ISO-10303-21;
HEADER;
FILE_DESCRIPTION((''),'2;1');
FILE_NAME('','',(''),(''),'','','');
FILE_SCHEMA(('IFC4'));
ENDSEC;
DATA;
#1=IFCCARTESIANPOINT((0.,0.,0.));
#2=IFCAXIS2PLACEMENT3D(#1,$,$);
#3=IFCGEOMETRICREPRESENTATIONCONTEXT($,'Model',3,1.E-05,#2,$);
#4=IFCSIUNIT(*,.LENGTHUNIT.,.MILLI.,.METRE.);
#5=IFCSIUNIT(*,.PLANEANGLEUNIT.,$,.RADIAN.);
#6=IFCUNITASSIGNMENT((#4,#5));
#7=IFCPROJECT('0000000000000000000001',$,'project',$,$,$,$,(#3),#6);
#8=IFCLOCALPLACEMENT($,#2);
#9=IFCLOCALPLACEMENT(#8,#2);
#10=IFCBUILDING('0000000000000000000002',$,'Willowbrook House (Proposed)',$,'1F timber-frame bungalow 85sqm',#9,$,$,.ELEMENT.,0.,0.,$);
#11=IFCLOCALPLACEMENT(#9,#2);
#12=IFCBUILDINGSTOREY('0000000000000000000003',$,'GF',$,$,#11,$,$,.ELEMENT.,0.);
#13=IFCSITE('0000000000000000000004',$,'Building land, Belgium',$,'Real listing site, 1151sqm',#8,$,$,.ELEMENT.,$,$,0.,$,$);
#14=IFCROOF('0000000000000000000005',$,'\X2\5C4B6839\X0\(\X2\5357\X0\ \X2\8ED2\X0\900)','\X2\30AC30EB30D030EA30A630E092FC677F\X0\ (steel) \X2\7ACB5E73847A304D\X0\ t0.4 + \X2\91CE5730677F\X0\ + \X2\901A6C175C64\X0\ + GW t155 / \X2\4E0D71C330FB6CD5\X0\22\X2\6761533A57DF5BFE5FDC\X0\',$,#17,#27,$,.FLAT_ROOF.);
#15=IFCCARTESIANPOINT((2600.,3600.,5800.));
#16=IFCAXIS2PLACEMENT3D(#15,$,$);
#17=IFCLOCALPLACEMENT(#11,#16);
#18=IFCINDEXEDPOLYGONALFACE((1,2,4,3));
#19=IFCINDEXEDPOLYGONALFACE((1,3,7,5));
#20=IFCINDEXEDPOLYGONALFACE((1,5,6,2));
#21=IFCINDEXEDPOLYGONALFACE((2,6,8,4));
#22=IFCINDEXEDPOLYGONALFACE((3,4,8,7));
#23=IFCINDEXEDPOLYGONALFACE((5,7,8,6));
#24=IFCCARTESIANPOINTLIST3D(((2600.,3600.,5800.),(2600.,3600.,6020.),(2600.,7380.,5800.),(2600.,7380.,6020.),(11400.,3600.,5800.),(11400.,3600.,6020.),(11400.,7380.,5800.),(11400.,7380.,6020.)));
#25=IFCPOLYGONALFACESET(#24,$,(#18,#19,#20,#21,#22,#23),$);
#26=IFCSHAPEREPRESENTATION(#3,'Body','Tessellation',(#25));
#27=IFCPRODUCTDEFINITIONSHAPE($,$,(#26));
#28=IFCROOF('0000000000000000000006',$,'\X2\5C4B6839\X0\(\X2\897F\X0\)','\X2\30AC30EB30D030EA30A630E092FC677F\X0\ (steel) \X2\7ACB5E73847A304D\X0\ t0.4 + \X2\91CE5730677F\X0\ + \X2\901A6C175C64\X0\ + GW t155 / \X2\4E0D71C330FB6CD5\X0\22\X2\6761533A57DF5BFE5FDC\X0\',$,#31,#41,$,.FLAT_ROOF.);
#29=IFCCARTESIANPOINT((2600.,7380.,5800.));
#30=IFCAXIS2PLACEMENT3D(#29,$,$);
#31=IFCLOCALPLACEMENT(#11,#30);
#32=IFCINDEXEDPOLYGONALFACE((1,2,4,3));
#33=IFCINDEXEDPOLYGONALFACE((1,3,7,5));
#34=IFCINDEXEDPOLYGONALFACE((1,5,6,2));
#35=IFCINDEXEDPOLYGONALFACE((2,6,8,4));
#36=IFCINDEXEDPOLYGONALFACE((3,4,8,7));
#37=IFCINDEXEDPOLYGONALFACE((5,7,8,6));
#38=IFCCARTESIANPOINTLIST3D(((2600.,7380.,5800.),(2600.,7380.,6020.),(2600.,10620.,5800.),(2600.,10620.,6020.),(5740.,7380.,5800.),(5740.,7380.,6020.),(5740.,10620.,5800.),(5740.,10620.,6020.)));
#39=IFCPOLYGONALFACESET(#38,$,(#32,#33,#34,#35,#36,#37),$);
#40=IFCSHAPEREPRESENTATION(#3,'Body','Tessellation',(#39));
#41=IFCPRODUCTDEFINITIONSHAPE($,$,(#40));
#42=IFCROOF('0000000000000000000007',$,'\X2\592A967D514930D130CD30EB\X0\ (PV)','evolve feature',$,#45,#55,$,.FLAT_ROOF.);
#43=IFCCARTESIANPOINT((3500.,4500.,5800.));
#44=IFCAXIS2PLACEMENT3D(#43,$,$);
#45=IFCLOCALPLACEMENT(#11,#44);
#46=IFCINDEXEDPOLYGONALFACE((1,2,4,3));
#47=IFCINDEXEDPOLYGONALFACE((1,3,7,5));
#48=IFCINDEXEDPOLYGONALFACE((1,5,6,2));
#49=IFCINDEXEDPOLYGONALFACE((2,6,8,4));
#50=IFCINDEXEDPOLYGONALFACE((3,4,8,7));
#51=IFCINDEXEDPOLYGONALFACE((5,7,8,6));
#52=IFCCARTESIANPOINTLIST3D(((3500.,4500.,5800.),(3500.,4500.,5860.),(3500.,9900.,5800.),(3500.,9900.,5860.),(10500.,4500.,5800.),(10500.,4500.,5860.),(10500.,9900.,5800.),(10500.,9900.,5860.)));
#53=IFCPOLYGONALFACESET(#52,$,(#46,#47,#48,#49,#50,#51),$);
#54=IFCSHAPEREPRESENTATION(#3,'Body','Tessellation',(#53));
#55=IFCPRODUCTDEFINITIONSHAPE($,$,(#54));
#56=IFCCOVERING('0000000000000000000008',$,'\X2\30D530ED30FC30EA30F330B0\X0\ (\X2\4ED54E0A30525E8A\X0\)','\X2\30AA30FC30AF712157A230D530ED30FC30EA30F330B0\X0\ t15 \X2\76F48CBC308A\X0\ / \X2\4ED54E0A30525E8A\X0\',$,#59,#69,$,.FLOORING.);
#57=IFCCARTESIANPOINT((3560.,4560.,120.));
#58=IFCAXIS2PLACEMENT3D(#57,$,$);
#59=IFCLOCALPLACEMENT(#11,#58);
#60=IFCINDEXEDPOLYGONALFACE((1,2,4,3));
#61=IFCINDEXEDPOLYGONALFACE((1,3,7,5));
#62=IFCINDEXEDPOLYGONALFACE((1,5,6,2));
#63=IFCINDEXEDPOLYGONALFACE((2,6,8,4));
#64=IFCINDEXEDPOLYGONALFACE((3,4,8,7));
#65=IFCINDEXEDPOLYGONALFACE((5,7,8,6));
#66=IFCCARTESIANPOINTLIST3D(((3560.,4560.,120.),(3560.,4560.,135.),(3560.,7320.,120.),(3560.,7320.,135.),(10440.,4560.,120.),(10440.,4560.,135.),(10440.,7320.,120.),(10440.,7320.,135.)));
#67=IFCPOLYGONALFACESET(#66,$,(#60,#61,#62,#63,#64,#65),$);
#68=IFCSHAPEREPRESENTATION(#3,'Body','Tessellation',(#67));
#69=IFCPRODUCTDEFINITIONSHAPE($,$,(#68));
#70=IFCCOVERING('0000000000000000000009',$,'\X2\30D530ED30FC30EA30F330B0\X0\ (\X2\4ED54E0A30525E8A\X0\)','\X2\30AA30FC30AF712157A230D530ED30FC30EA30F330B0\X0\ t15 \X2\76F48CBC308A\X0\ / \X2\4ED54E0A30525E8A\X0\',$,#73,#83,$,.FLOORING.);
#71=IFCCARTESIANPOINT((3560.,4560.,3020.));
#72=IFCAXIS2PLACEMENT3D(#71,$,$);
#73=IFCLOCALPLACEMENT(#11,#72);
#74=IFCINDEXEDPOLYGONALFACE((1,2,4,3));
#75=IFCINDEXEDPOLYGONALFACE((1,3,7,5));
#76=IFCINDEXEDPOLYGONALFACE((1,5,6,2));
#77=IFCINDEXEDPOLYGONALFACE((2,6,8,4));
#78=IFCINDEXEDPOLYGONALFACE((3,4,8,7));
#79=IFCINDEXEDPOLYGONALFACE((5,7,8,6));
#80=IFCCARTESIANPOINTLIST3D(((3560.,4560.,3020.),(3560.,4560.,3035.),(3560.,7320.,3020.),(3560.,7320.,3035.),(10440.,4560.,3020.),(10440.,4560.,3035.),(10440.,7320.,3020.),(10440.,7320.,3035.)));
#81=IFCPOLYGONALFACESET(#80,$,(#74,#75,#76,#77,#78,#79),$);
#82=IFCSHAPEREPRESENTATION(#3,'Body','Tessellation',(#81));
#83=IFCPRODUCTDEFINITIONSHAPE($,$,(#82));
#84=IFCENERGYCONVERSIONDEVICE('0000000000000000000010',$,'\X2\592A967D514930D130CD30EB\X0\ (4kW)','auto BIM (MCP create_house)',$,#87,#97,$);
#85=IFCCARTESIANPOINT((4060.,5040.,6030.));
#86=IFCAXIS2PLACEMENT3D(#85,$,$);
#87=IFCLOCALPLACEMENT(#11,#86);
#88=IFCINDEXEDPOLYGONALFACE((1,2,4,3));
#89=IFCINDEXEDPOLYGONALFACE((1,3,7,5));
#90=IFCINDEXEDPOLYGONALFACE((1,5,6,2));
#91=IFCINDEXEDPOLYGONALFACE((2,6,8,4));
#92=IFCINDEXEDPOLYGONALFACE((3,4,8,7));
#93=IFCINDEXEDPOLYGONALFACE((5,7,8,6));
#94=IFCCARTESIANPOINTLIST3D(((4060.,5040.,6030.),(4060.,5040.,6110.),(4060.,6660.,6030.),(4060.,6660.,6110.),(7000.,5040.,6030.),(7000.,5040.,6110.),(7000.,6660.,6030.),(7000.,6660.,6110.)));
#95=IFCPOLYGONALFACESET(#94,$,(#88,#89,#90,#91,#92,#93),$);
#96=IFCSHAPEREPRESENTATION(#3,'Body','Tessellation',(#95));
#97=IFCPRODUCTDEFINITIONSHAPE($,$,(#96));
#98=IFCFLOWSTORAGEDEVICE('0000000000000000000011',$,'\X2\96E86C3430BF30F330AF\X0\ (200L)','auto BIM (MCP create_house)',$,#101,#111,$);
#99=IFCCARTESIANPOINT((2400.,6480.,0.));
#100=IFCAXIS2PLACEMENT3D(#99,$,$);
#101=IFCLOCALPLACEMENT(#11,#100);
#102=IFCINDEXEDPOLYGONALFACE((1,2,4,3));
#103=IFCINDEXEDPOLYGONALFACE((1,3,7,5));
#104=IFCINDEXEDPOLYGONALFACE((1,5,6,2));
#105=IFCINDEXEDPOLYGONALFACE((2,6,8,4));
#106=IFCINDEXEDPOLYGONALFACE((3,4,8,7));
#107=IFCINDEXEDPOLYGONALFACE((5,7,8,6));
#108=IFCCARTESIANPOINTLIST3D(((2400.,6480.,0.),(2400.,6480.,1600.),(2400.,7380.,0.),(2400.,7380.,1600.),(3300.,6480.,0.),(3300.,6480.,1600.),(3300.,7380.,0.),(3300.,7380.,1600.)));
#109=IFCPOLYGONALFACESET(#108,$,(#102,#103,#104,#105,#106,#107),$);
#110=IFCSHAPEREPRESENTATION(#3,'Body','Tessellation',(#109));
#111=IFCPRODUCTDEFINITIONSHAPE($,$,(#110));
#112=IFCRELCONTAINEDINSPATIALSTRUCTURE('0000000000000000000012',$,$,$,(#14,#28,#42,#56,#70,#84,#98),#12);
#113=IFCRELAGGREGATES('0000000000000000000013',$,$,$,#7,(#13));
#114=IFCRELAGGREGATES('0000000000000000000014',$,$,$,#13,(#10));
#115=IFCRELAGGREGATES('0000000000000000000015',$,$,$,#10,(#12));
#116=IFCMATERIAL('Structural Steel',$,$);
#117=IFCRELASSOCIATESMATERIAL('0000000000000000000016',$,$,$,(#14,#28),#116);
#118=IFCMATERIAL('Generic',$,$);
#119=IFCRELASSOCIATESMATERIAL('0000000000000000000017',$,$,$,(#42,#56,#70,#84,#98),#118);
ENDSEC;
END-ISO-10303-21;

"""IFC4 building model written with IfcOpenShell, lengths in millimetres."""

from ifc_helpers import new_model, si_unit, frame, frame_2d, origin, place, context, project, spatial, rectangle, extrude, material, element, save


model = new_model("IFC4")

# Units and contexts
model_context = context("Model", 3, precision=1e-05, world=origin())
ifc_project = project(units=[si_unit("LENGTHUNIT", "METRE", prefix="MILLI"), si_unit("PLANEANGLEUNIT", "RADIAN")], contexts=[model_context])

# Site, building, storey
site_placement = place(None, origin())
site = spatial("IfcSite", under=ifc_project, at=site_placement, Name="Building land, Belgium", ObjectType="Real listing site, 1151sqm", CompositionType="ELEMENT", RefElevation=0.0)
building_placement = place(site_placement, origin())
building = spatial("IfcBuilding", under=site, at=building_placement, Name="Willowbrook House (Proposed)", ObjectType="1F timber-frame bungalow 85sqm", CompositionType="ELEMENT", ElevationOfRefHeight=0.0, ElevationOfTerrain=0.0)
storey_placement = place(building_placement, origin())
storey = spatial("IfcBuildingStorey", under=building, at=storey_placement, Name="GF", CompositionType="ELEMENT", Elevation=0.0)

# Shared definitions
ifc_material_1 = material(Name="Generic")

# Roofs
ifc_material_2 = material(Name="Structural Steel")
roof_1_placement = place(storey_placement, frame((2600.0, 3600.0, 5800.0)))
element("IfcRoof", 1, at=roof_1_placement, inside=storey, material=ifc_material_2, Name="屋根(南 軒900)", Description="ガルバリウム鋼板 (steel) 立平葺き t0.4 + 野地板 + 通気層 + GW t155 / 不燃・法22条区域対応", PredefinedType="FLAT_ROOF", context=model_context, shape_type="SweptSolid", body=[
    extrude(rectangle(XDim=8800.0, YDim=3780.0, at=frame_2d((4400.0, 1890.0))), frame((2600.0, 3600.0, 5800.0)), (0.0, 0.0, 1.0), 220.0),
])
roof_2_placement = place(storey_placement, frame((2600.0, 7380.0, 5800.0)))
element("IfcRoof", 2, at=roof_2_placement, inside=storey, material=ifc_material_2, Name="屋根(西)", Description="ガルバリウム鋼板 (steel) 立平葺き t0.4 + 野地板 + 通気層 + GW t155 / 不燃・法22条区域対応", PredefinedType="FLAT_ROOF", context=model_context, shape_type="SweptSolid", body=[
    extrude(rectangle(XDim=3140.0, YDim=3240.0, at=frame_2d((1570.0, 1620.0))), frame((2600.0, 7380.0, 5800.0)), (0.0, 0.0, 1.0), 220.0),
])
roof_3_placement = place(storey_placement, frame((3500.0, 4500.0, 5800.0)))
element("IfcRoof", 3, at=roof_3_placement, inside=storey, material=ifc_material_1, Name="太陽光パネル (PV)", Description="evolve feature", PredefinedType="FLAT_ROOF", context=model_context, shape_type="SweptSolid", body=[
    extrude(rectangle(XDim=7000.0, YDim=5400.0, at=frame_2d((3500.0, 2700.0))), frame((3500.0, 4500.0, 5800.0)), (0.0, 0.0, 1.0), 60.0),
])

# Coverings
covering_1_placement = place(storey_placement, frame((3560.0, 4560.0, 120.0)))
element("IfcCovering", 4, at=covering_1_placement, inside=storey, material=ifc_material_1, Name="フローリング (仕上げ床)", Description="オーク無垢フローリング t15 直貼り / 仕上げ床", PredefinedType="FLOORING", context=model_context, shape_type="SweptSolid", body=[
    extrude(rectangle(XDim=6880.0, YDim=2760.0, at=frame_2d((3440.0, 1380.0))), frame((3560.0, 4560.0, 120.0)), (0.0, 0.0, 1.0), 15.0),
])
covering_2_placement = place(storey_placement, frame((3560.0, 4560.0, 3020.0)))
element("IfcCovering", 5, at=covering_2_placement, inside=storey, material=ifc_material_1, Name="フローリング (仕上げ床)", Description="オーク無垢フローリング t15 直貼り / 仕上げ床", PredefinedType="FLOORING", context=model_context, shape_type="SweptSolid", body=[
    extrude(rectangle(XDim=6880.0, YDim=2760.0, at=frame_2d((3440.0, 1380.0))), frame((3560.0, 4560.0, 3020.0)), (0.0, 0.0, 1.0), 15.0),
])

# Energy conversion device
energy_conversion_device_placement = place(storey_placement, frame((4060.0, 5040.0, 6030.0)))
element("IfcEnergyConversionDevice", 6, at=energy_conversion_device_placement, inside=storey, material=ifc_material_1, Name="太陽光パネル (4kW)", Description="auto BIM (MCP create_house)", context=model_context, shape_type="SweptSolid", body=[
    extrude(rectangle(XDim=2940.0, YDim=1620.0, at=frame_2d((1470.0, 810.0))), frame((4060.0, 5040.0, 6030.0)), (0.0, 0.0, 1.0), 80.0),
])

# Flow storage device
flow_storage_device_placement = place(storey_placement, frame((2400.0, 6480.0, 0.0)))
element("IfcFlowStorageDevice", 7, at=flow_storage_device_placement, inside=storey, material=ifc_material_1, Name="雨水タンク (200L)", Description="auto BIM (MCP create_house)", context=model_context, shape_type="SweptSolid", body=[
    extrude(rectangle(XDim=900.0, YDim=900.0, at=frame_2d((450.0, 450.0))), frame((2400.0, 6480.0, 0.0)), (0.0, 0.0, 1.0), 1600.0),
])

save(model, "model.ifc")
